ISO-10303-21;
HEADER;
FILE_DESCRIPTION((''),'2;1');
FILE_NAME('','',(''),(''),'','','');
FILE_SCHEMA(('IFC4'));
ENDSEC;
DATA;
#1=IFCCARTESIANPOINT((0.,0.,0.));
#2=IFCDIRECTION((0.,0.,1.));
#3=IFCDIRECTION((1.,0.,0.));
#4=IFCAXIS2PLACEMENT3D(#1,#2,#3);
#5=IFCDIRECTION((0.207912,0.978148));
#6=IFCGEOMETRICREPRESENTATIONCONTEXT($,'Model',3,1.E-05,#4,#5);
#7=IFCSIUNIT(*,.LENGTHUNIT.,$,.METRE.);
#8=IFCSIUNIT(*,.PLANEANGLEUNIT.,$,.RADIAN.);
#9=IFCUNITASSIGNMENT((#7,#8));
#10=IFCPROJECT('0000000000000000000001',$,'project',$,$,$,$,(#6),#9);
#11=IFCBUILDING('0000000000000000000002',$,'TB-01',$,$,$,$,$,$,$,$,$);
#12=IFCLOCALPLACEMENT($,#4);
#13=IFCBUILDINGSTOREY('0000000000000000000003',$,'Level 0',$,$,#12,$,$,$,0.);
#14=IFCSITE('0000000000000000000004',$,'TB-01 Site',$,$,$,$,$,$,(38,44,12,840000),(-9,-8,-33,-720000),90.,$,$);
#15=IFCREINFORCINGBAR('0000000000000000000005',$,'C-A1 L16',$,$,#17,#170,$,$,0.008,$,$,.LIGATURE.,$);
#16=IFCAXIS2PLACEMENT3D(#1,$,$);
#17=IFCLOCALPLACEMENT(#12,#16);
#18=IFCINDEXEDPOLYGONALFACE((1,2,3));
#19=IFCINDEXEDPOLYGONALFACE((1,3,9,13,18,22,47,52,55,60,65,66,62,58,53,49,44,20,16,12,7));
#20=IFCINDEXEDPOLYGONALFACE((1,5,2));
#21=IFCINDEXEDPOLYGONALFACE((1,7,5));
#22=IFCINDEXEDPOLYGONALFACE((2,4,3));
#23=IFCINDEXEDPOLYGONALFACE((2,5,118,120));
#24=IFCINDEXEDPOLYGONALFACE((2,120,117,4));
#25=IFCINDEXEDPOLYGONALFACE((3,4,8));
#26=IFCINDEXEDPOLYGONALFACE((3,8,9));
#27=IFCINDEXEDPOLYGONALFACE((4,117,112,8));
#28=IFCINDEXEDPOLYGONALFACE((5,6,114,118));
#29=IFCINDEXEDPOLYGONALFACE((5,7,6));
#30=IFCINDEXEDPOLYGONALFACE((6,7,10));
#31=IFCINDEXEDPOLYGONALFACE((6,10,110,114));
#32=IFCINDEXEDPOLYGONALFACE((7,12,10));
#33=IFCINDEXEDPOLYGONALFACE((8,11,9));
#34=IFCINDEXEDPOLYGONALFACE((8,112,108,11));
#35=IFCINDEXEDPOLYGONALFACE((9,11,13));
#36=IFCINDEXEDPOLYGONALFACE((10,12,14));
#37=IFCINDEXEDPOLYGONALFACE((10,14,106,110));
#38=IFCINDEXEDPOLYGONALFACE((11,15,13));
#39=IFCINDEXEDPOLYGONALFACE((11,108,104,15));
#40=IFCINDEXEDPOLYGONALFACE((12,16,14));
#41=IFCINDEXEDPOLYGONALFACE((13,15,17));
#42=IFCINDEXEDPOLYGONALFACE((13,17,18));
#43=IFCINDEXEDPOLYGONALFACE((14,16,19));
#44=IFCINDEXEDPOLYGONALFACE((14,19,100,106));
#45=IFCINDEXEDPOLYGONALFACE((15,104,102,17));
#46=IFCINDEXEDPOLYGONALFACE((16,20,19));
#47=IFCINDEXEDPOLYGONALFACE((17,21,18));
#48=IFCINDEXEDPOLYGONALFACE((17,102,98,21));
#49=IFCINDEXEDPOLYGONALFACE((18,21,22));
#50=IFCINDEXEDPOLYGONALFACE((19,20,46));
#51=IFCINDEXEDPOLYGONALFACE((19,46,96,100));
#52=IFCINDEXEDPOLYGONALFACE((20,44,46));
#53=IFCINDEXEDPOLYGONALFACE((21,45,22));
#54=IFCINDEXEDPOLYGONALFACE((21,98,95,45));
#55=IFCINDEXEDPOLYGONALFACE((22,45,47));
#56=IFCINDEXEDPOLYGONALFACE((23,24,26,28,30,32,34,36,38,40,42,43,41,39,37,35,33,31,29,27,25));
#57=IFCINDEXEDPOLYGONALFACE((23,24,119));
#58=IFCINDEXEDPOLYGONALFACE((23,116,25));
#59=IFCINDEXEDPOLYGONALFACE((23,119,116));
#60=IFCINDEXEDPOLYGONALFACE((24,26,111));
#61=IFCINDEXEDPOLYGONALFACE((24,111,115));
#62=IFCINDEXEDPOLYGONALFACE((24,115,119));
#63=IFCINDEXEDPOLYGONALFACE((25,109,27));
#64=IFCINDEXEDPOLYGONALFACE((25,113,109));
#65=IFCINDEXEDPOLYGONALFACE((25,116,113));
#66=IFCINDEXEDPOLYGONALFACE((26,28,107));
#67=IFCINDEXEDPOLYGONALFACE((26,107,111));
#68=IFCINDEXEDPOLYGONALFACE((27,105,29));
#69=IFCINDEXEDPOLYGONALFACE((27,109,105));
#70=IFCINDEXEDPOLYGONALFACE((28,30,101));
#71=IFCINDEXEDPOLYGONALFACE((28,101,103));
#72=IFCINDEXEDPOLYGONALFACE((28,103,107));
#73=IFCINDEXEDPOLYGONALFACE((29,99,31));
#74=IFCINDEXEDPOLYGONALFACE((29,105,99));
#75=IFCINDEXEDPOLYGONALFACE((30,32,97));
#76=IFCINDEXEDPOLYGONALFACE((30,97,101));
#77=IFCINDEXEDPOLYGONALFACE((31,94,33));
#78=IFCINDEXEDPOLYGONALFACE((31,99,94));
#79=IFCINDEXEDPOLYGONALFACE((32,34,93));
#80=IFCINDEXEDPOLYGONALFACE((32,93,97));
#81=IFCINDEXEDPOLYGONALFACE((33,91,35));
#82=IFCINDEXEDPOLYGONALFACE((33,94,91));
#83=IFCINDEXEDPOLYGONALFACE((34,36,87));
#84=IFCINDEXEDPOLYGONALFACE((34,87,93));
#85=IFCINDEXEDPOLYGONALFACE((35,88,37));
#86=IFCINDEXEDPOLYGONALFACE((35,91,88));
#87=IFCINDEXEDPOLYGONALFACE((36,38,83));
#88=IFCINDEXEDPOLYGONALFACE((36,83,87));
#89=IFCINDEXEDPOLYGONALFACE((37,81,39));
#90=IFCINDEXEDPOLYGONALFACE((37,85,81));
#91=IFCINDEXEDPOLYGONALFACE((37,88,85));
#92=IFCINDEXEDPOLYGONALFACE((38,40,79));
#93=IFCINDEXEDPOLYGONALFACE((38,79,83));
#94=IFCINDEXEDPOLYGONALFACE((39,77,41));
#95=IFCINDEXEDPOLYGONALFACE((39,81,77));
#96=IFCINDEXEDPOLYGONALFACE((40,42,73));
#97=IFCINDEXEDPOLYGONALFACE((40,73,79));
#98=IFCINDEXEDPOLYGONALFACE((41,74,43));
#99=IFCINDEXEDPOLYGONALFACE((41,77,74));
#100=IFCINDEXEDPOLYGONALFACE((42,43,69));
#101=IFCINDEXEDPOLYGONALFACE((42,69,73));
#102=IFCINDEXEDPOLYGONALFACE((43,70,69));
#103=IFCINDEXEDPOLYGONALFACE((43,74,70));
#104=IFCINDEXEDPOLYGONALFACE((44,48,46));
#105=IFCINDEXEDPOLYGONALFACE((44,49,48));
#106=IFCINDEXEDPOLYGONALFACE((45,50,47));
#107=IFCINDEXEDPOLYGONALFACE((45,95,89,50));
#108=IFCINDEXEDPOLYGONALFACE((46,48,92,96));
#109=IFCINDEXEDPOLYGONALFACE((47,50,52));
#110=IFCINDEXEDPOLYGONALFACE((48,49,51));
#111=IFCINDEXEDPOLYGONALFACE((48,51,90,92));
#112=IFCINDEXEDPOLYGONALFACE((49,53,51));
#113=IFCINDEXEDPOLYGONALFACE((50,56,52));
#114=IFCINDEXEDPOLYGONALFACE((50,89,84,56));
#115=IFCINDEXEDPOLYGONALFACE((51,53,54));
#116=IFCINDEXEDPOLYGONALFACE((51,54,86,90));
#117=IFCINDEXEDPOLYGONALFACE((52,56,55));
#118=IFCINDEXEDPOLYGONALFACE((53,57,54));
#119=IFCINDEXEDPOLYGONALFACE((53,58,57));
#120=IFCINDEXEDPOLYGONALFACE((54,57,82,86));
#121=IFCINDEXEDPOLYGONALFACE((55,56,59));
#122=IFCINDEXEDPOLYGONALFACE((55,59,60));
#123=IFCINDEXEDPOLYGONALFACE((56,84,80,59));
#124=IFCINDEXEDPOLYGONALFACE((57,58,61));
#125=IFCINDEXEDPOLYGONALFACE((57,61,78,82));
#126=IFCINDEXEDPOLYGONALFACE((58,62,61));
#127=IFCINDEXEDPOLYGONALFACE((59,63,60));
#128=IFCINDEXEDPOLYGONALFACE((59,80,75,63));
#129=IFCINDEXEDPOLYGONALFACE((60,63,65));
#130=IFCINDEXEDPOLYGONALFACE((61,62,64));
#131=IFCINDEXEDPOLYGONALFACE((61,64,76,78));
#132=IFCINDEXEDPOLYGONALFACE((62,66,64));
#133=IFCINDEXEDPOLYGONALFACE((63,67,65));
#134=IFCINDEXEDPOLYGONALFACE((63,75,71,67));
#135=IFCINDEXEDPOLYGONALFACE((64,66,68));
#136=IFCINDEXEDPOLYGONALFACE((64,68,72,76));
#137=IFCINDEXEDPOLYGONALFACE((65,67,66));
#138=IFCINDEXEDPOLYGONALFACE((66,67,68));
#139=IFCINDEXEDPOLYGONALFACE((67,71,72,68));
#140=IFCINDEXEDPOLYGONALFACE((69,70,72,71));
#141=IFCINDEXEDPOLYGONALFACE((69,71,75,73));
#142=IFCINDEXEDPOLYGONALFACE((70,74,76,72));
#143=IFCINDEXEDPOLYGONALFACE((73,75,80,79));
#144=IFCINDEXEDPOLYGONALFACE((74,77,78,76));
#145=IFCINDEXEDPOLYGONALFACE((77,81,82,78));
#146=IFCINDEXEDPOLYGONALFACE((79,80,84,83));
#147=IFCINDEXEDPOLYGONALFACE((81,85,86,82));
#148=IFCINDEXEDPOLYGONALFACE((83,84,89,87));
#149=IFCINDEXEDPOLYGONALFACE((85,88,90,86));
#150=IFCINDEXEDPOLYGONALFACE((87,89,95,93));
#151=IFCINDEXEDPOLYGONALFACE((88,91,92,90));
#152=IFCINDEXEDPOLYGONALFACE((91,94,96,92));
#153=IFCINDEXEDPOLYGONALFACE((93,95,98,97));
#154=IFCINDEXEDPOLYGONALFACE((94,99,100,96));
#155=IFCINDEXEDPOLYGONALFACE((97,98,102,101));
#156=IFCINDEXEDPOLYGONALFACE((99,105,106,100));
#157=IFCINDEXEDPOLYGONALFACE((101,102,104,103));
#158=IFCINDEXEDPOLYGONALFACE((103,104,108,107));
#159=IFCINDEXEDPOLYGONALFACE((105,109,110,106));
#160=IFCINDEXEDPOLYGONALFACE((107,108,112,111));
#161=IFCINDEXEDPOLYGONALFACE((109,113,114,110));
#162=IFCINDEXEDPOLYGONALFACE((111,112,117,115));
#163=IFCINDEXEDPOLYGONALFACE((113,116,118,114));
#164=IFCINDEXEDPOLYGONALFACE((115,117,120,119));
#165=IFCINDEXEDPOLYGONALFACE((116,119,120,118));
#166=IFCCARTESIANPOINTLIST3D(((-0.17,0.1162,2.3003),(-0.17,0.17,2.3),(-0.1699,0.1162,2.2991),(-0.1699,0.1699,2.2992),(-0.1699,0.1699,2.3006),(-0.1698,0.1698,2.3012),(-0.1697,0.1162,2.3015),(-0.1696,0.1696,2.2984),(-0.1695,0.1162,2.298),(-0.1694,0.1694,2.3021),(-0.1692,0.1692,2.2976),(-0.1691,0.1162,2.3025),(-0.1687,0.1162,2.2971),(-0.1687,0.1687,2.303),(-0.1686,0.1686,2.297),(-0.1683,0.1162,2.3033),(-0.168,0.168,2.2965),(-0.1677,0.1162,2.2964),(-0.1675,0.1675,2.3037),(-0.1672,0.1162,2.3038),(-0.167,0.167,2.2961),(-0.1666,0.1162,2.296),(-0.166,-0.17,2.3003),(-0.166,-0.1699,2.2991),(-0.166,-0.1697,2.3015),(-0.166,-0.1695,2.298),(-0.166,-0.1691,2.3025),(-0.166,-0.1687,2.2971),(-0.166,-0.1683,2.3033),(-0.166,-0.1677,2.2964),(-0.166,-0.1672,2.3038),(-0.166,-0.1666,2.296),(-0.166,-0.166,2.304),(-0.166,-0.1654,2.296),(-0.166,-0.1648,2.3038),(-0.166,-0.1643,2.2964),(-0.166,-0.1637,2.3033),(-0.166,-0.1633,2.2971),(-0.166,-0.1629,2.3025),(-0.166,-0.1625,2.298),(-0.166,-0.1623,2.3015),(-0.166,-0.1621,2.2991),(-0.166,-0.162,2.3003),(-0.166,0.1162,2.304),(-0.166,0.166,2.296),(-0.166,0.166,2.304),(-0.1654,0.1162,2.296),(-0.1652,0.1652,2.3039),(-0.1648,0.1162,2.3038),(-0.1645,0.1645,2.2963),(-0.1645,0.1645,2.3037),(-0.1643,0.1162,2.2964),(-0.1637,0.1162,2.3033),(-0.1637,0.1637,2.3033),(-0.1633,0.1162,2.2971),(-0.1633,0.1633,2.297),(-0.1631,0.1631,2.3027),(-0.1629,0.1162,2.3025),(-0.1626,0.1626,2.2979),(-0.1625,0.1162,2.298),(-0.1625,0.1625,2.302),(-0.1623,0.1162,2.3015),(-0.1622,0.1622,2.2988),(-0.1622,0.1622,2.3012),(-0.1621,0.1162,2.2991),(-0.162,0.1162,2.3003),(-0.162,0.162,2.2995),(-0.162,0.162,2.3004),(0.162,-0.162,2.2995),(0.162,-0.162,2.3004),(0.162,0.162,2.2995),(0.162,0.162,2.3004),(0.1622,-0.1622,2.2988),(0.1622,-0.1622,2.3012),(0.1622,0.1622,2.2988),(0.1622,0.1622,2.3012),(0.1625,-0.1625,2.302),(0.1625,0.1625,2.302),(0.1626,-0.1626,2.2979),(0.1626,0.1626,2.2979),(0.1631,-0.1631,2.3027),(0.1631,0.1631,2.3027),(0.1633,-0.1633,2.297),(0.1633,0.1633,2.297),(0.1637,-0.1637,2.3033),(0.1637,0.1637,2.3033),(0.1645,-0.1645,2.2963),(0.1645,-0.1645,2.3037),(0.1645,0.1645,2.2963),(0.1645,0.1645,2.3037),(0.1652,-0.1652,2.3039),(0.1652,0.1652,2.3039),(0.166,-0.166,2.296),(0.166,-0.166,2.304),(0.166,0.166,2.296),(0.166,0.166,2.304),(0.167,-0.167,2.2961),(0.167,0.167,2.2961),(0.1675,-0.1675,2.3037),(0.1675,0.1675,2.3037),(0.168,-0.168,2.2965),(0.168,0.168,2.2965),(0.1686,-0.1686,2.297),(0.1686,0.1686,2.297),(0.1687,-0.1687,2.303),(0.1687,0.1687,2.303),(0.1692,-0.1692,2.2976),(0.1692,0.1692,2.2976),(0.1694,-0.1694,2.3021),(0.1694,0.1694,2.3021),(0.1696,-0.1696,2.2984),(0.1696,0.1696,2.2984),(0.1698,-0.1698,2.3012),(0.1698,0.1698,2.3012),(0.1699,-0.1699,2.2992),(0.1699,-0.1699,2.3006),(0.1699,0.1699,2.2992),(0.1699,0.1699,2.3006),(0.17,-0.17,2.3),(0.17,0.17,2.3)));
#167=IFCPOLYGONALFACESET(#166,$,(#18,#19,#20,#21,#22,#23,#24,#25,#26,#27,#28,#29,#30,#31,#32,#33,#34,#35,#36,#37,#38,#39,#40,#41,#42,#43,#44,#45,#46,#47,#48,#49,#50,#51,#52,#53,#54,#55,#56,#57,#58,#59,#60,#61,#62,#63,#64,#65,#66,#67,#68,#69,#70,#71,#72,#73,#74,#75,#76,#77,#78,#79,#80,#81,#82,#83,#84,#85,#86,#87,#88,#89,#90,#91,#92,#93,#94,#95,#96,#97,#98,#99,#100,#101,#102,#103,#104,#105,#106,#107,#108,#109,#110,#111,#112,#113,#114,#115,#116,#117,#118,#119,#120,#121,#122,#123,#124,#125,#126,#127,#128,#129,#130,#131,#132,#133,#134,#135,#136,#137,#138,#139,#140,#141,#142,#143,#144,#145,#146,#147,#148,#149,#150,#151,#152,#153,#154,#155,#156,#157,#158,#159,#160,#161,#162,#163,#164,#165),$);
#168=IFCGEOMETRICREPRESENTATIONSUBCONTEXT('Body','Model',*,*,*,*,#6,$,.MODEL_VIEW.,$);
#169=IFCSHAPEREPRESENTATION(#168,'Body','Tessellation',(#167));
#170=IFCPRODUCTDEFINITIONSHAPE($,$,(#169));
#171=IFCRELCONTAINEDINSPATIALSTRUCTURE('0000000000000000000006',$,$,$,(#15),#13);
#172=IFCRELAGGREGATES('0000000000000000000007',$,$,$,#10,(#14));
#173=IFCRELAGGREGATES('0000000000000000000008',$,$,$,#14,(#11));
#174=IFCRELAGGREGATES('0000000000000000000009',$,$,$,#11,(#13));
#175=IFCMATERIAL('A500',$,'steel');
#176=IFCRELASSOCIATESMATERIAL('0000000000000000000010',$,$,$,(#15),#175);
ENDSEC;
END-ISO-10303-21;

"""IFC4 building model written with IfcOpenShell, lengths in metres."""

from ifc_helpers import new_model, entity, si_unit, direction, origin_with_axes, place, context, subcontext, project, spatial, material, element, save


model = new_model("IFC4")

# Units and contexts
model_context = context("Model", 3, precision=1e-05, world=origin_with_axes(), true_north=direction((0.207912, 0.978148)))
body_context = subcontext(model_context, "Body", "Model", "MODEL_VIEW")
ifc_project = project(units=[si_unit("LENGTHUNIT", "METRE"), si_unit("PLANEANGLEUNIT", "RADIAN")], contexts=[model_context])

# Site, building, storey
site = spatial("IfcSite", under=ifc_project, Name="TB-01 Site", RefLatitude=(38, 44, 12, 840000), RefLongitude=(-9, -8, -33, -720000), RefElevation=90.0)
building = spatial("IfcBuilding", under=site, Name="TB-01")
storey_placement = place(None, origin_with_axes())
storey = spatial("IfcBuildingStorey", under=building, at=storey_placement, Name="Level 0", Elevation=0.0)

# Reinforcing bar
ifc_material_1 = material(Name="A500", Category="steel")
reinforcing_bar_1_placement = place(storey_placement, origin_with_axes())
element("IfcReinforcingBar", 1, at=reinforcing_bar_1_placement, inside=storey, material=ifc_material_1, Name="C-A1 L16", NominalDiameter=0.008, PredefinedType="LIGATURE", context=body_context, shape_type="AdvancedSweptSolid", body=[
    entity("IfcSweptDiskSolid", entity("IfcPolyline", [entity("IfcCartesianPoint", [-0.166, -0.166, 2.3]), entity("IfcCartesianPoint", [0.166, -0.166, 2.3]), entity("IfcCartesianPoint", [0.166, 0.166, 2.3]), entity("IfcCartesianPoint", [-0.166, 0.166, 2.3]), entity("IfcCartesianPoint", [-0.166, 0.1162, 2.3])]), 0.004),
])

save(model, "model.ifc")
